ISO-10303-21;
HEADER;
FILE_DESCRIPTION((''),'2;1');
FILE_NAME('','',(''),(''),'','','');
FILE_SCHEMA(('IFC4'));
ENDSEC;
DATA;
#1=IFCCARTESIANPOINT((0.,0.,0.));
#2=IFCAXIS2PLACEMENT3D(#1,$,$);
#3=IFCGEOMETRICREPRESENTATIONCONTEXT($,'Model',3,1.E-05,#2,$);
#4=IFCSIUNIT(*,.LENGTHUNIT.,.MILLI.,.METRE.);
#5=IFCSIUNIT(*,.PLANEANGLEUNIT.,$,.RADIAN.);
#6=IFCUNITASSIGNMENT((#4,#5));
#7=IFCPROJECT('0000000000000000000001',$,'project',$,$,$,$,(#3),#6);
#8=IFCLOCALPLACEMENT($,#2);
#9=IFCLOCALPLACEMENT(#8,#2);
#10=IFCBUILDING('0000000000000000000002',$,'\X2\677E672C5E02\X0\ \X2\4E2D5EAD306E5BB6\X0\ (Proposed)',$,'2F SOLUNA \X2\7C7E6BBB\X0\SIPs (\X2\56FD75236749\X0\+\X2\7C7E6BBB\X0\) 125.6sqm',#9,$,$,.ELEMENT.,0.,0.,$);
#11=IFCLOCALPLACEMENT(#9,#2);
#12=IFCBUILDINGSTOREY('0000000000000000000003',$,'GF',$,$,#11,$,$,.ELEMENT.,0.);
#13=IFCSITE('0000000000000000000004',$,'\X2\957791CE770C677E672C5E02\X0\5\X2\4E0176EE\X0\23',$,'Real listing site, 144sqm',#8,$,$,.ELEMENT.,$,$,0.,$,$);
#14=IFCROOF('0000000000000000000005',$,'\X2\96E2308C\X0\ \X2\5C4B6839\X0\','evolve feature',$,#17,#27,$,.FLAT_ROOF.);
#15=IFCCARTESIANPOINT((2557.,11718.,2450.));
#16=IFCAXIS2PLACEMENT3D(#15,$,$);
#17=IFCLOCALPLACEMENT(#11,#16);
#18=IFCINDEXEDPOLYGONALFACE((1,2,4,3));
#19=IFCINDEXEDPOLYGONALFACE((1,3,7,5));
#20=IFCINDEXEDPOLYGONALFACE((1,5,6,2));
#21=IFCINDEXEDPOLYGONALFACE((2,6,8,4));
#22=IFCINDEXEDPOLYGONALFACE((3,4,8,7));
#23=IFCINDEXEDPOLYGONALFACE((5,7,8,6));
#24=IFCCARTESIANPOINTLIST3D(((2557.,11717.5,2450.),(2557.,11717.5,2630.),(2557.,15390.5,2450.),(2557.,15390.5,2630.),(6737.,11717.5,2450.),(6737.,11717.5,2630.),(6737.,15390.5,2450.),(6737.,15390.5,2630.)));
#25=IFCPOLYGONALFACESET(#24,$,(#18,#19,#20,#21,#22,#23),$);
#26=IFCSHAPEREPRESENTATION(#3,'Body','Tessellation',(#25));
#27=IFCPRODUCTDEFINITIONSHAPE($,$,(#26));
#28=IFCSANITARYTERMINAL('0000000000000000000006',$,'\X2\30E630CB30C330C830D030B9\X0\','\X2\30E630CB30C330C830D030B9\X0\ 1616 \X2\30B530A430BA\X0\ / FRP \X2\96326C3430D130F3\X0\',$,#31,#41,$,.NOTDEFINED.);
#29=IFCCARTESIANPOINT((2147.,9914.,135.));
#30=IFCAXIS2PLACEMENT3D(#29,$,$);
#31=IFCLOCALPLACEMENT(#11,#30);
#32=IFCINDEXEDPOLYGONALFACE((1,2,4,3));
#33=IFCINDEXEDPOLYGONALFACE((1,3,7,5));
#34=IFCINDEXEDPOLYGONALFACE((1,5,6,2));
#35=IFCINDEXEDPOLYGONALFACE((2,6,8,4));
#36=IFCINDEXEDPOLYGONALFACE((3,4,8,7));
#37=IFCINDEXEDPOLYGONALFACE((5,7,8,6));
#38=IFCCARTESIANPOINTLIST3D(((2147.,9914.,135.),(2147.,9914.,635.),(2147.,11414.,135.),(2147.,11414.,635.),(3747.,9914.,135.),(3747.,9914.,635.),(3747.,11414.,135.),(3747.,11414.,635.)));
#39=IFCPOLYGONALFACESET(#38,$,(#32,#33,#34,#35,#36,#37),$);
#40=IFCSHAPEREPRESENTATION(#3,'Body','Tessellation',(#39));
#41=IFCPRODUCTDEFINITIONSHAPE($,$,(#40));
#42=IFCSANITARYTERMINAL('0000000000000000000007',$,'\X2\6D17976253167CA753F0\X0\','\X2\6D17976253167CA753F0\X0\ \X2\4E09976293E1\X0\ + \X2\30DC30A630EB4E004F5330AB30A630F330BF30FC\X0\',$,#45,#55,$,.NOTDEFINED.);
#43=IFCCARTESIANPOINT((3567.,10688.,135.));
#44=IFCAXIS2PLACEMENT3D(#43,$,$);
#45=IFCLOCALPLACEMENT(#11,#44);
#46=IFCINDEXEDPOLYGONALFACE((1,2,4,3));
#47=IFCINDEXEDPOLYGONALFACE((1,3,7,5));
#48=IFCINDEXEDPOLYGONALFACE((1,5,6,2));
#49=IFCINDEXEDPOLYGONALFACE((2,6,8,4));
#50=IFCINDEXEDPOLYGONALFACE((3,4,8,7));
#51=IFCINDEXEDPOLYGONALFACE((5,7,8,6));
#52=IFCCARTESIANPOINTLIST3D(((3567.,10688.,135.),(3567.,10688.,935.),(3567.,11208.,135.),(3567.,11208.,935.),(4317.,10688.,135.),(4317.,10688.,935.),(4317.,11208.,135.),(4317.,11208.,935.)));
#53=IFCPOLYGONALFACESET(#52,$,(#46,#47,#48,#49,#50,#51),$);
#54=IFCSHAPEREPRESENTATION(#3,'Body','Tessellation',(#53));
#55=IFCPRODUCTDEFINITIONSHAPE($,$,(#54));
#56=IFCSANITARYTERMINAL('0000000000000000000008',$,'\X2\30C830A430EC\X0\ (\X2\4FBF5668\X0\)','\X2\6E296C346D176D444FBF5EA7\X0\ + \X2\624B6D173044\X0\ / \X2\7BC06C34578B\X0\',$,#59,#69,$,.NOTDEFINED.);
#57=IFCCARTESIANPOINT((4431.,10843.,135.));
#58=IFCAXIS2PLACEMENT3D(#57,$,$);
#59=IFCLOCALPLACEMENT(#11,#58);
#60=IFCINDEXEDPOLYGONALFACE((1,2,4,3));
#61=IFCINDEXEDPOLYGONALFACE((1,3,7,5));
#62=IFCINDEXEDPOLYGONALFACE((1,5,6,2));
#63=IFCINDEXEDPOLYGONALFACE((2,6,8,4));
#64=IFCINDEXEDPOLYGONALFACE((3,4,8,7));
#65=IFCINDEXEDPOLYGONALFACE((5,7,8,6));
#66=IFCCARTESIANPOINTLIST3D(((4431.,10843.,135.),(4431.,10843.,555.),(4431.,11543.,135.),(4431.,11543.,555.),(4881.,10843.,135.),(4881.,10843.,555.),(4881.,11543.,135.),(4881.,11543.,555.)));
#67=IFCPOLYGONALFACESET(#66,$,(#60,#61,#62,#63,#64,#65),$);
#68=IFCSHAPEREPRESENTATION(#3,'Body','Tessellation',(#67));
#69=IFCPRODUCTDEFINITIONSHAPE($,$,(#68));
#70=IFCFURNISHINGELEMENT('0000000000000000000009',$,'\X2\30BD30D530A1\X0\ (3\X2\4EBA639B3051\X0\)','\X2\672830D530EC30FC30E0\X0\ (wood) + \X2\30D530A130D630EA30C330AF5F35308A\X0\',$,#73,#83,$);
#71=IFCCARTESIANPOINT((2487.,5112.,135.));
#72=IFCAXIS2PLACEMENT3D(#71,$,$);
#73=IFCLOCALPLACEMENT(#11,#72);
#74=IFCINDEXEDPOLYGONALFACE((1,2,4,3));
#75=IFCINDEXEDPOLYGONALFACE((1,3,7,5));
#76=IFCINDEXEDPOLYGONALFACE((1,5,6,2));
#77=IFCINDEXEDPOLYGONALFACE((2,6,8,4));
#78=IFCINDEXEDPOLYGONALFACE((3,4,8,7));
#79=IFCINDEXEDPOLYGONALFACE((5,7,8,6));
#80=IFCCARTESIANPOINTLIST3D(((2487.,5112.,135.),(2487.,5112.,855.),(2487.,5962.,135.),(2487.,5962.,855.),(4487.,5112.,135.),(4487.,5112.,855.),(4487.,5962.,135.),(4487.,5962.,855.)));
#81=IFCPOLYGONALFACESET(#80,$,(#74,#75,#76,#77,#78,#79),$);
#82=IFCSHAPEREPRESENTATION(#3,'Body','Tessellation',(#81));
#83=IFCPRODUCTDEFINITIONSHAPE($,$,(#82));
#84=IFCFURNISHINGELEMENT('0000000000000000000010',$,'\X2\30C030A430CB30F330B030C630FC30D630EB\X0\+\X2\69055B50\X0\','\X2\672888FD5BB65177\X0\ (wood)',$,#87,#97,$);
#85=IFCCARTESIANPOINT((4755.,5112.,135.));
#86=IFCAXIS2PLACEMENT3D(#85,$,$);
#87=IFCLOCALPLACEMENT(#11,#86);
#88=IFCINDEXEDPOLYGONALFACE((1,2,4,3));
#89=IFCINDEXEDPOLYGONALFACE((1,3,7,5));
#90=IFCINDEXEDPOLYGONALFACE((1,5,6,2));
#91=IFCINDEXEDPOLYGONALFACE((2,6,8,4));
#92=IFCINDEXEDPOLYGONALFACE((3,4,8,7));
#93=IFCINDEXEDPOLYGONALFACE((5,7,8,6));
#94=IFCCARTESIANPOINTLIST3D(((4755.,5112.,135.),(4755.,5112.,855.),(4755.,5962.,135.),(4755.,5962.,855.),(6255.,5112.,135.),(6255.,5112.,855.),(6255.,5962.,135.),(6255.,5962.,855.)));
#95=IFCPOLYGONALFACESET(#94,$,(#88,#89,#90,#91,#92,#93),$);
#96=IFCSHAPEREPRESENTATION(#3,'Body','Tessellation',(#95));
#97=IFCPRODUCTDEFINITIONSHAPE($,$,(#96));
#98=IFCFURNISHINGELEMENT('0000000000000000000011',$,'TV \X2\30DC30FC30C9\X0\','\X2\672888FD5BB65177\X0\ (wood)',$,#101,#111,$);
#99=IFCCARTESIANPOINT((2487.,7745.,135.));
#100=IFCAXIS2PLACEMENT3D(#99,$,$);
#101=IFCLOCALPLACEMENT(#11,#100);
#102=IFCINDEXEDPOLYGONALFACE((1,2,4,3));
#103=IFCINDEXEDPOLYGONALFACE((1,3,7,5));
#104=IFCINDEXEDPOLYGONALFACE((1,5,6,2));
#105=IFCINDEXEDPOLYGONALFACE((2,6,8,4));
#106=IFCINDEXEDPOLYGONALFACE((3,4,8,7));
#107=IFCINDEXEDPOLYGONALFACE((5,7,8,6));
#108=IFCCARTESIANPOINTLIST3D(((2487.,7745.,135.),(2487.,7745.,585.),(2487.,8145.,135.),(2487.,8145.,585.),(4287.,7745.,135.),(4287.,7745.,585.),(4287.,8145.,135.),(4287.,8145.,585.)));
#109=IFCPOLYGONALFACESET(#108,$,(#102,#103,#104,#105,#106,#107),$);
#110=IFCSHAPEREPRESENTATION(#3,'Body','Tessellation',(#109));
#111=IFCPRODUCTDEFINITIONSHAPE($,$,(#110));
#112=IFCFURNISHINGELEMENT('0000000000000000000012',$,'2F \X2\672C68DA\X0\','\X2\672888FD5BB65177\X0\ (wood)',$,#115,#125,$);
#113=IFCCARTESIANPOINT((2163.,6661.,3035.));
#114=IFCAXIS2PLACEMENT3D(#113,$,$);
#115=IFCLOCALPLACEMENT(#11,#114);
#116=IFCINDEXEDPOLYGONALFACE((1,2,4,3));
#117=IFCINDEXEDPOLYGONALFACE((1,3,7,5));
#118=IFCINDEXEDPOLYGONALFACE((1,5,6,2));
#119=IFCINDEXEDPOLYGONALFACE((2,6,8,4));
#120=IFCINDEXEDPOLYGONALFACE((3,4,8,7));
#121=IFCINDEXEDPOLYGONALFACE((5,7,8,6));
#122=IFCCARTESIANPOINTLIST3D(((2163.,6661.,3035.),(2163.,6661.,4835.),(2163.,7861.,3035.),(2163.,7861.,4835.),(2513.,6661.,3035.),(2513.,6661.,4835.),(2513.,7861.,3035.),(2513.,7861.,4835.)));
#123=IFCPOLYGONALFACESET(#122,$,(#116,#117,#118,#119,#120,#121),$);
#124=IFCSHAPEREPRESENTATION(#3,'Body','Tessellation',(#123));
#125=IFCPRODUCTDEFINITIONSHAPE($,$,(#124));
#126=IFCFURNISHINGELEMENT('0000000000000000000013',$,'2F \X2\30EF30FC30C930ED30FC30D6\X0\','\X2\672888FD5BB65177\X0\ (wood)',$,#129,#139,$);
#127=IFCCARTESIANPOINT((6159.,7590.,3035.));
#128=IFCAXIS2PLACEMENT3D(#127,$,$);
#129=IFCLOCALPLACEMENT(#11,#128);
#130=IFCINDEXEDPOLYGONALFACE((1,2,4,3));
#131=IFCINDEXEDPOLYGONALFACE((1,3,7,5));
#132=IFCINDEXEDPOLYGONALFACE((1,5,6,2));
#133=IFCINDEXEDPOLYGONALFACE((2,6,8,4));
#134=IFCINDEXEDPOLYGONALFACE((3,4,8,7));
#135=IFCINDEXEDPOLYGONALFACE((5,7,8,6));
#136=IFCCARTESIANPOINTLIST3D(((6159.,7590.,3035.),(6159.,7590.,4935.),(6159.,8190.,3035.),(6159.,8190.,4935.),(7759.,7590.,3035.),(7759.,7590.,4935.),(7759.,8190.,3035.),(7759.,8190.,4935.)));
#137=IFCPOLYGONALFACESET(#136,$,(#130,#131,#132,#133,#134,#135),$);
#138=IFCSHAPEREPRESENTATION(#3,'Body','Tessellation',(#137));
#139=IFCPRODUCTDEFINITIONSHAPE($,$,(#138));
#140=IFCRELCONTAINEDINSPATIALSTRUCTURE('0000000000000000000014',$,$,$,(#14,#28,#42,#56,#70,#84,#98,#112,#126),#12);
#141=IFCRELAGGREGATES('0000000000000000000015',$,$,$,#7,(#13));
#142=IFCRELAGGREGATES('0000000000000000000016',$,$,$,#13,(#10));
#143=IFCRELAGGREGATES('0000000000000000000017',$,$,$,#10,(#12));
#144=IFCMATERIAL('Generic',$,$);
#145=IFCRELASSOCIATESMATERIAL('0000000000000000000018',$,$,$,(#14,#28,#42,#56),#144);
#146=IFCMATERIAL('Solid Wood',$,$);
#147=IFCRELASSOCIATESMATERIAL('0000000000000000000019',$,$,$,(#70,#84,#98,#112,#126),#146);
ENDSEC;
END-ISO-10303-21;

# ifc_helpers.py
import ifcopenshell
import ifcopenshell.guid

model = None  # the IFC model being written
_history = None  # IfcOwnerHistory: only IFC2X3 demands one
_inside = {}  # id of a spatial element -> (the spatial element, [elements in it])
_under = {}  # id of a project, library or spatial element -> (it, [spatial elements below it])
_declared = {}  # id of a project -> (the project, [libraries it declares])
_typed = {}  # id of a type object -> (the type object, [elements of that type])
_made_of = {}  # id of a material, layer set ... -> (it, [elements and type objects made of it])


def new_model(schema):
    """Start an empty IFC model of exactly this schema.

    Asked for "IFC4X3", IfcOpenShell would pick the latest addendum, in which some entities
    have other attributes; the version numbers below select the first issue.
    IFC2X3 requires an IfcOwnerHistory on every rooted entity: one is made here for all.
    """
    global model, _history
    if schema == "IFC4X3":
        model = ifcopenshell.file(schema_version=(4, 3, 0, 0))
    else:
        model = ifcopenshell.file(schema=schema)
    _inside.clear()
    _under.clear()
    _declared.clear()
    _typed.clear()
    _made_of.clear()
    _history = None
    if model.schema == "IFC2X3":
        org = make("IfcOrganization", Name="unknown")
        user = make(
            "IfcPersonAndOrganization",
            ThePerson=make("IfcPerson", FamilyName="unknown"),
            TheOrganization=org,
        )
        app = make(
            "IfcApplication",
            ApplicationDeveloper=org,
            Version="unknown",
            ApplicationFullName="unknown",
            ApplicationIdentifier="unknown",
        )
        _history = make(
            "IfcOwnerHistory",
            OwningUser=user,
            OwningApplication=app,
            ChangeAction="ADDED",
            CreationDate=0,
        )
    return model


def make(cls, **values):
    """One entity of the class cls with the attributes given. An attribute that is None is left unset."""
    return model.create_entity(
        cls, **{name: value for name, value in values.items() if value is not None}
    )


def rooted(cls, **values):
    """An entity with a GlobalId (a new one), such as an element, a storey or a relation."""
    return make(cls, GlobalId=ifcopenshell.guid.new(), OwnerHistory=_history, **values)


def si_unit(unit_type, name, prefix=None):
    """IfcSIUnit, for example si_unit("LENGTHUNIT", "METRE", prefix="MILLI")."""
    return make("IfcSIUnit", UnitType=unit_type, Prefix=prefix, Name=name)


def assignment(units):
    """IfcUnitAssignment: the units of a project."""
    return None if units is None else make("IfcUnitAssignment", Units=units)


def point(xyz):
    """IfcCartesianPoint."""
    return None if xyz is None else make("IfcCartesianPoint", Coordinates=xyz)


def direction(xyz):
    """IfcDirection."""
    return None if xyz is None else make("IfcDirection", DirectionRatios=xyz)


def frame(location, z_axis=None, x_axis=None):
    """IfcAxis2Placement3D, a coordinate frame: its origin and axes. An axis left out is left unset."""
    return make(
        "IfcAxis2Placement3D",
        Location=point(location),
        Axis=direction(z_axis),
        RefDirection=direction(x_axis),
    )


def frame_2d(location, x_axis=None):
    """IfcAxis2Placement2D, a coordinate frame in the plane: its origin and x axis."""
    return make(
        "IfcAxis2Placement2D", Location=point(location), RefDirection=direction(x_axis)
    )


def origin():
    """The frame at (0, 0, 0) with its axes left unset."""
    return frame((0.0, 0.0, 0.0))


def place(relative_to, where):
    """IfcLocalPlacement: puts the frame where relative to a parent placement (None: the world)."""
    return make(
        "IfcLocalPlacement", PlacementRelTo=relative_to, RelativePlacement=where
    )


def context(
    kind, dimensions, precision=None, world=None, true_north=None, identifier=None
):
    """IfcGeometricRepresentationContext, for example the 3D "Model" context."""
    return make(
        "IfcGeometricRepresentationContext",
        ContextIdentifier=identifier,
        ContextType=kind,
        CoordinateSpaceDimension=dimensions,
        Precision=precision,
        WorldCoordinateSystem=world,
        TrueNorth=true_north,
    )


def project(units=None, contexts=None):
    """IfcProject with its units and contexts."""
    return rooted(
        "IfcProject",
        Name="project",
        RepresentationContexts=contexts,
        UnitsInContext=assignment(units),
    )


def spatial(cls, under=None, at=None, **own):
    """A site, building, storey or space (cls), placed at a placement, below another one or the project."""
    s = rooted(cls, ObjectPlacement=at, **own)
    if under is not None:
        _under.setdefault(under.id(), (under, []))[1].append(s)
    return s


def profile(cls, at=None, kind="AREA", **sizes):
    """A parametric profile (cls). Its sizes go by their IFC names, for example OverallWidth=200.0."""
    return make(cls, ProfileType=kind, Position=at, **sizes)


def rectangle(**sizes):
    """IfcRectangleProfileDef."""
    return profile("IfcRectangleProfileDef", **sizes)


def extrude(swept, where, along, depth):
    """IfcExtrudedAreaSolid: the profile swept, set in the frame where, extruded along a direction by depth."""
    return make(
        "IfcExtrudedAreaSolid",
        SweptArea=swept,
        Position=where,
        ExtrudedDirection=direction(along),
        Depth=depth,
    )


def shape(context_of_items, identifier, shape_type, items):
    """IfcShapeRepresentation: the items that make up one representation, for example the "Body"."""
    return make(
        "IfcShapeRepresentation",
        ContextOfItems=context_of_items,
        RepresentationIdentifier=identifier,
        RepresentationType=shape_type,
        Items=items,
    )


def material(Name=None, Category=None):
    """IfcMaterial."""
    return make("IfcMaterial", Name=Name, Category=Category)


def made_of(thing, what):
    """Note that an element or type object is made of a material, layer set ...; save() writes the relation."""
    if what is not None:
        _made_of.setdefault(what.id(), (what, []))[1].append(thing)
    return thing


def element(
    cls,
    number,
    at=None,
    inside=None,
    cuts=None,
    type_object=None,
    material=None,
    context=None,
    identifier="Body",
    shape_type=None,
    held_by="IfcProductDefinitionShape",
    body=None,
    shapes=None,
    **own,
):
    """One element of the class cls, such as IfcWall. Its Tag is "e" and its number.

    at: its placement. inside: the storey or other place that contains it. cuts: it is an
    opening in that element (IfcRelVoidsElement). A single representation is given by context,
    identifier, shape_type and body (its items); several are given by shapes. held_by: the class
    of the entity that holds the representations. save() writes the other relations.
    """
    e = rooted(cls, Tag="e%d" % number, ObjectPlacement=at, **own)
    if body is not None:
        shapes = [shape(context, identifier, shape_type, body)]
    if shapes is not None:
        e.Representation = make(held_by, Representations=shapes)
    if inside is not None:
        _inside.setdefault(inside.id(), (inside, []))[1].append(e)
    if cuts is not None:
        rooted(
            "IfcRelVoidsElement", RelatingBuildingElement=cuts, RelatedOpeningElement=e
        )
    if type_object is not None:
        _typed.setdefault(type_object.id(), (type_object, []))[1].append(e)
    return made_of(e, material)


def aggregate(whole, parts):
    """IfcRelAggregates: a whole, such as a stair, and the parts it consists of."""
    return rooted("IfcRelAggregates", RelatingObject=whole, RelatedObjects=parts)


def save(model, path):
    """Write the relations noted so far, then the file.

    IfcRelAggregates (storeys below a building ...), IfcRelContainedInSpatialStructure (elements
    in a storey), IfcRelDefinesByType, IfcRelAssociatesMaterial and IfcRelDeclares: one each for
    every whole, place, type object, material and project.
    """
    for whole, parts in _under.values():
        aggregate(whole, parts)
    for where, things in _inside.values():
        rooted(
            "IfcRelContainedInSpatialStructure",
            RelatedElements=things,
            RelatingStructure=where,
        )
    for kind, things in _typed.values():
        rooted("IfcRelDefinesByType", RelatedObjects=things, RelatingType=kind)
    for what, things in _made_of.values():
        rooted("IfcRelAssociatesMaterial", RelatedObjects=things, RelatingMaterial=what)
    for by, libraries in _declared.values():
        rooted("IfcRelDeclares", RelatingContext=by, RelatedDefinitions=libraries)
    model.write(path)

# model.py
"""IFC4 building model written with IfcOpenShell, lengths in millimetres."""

from ifc_helpers import new_model, si_unit, frame, frame_2d, origin, place, context, project, spatial, rectangle, extrude, material, element, save


model = new_model("IFC4")

# Units and contexts
model_context = context("Model", 3, precision=1e-05, world=origin())
ifc_project = project(units=[si_unit("LENGTHUNIT", "METRE", prefix="MILLI"), si_unit("PLANEANGLEUNIT", "RADIAN")], contexts=[model_context])

# Site, building, storey
site_placement = place(None, origin())
site = spatial("IfcSite", under=ifc_project, at=site_placement, Name="長野県松本市5丁目23", ObjectType="Real listing site, 144sqm", CompositionType="ELEMENT", RefElevation=0.0)
building_placement = place(site_placement, origin())
building = spatial("IfcBuilding", under=site, at=building_placement, Name="松本市 中庭の家 (Proposed)", ObjectType="2F SOLUNA 籾殻SIPs (国産杉+籾殻) 125.6sqm", CompositionType="ELEMENT", ElevationOfRefHeight=0.0, ElevationOfTerrain=0.0)
storey_placement = place(building_placement, origin())
storey = spatial("IfcBuildingStorey", under=building, at=storey_placement, Name="GF", CompositionType="ELEMENT", Elevation=0.0)

# Shared definitions
ifc_material_1 = material(Name="Generic")

# Shared definitions
ifc_material_2 = material(Name="Solid Wood")

# Roof
roof_1_placement = place(storey_placement, frame((2557.0, 11718.0, 2450.0)))
element("IfcRoof", 1, at=roof_1_placement, inside=storey, material=ifc_material_1, Name="離れ 屋根", Description="evolve feature", PredefinedType="FLAT_ROOF", context=model_context, shape_type="SweptSolid", body=[
    extrude(rectangle(XDim=4180.0, YDim=3673.0, at=frame_2d((2090.0, 1836.0))), frame((2557.0, 11718.0, 2450.0)), (0.0, 0.0, 1.0), 180.0),
])

# Sanitary terminals
sanitary_terminal_1_placement = place(storey_placement, frame((2147.0, 9914.0, 135.0)))
element("IfcSanitaryTerminal", 2, at=sanitary_terminal_1_placement, inside=storey, material=ifc_material_1, Name="ユニットバス", Description="ユニットバス 1616 サイズ / FRP 防水パン", PredefinedType="NOTDEFINED", context=model_context, shape_type="SweptSolid", body=[
    extrude(rectangle(XDim=1600.0, YDim=1500.0, at=frame_2d((800.0, 750.0))), frame((2147.0, 9914.0, 135.0)), (0.0, 0.0, 1.0), 500.0),
])
sanitary_terminal_2_placement = place(storey_placement, frame((3567.0, 10688.0, 135.0)))
element("IfcSanitaryTerminal", 3, at=sanitary_terminal_2_placement, inside=storey, material=ifc_material_1, Name="洗面化粧台", Description="洗面化粧台 三面鏡 + ボウル一体カウンター", PredefinedType="NOTDEFINED", context=model_context, shape_type="SweptSolid", body=[
    extrude(rectangle(XDim=750.0, YDim=520.0, at=frame_2d((375.0, 260.0))), frame((3567.0, 10688.0, 135.0)), (0.0, 0.0, 1.0), 800.0),
])
sanitary_terminal_3_placement = place(storey_placement, frame((4431.0, 10843.0, 135.0)))
element("IfcSanitaryTerminal", 4, at=sanitary_terminal_3_placement, inside=storey, material=ifc_material_1, Name="トイレ (便器)", Description="温水洗浄便座 + 手洗い / 節水型", PredefinedType="NOTDEFINED", context=model_context, shape_type="SweptSolid", body=[
    extrude(rectangle(XDim=450.0, YDim=700.0, at=frame_2d((225.0, 350.0))), frame((4431.0, 10843.0, 135.0)), (0.0, 0.0, 1.0), 420.0),
])

# Furnishing elements
furnishing_1_placement = place(storey_placement, frame((2487.0, 5112.0, 135.0)))
element("IfcFurnishingElement", 5, at=furnishing_1_placement, inside=storey, material=ifc_material_2, Name="ソファ (3人掛け)", Description="木フレーム (wood) + ファブリック張り", context=model_context, shape_type="SweptSolid", body=[
    extrude(rectangle(XDim=2000.0, YDim=850.0, at=frame_2d((1000.0, 425.0))), frame((2487.0, 5112.0, 135.0)), (0.0, 0.0, 1.0), 720.0),
])
furnishing_2_placement = place(storey_placement, frame((4755.0, 5112.0, 135.0)))
element("IfcFurnishingElement", 6, at=furnishing_2_placement, inside=storey, material=ifc_material_2, Name="ダイニングテーブル+椅子", Description="木製家具 (wood)", context=model_context, shape_type="SweptSolid", body=[
    extrude(rectangle(XDim=1500.0, YDim=850.0, at=frame_2d((750.0, 425.0))), frame((4755.0, 5112.0, 135.0)), (0.0, 0.0, 1.0), 720.0),
])
furnishing_3_placement = place(storey_placement, frame((2487.0, 7745.0, 135.0)))
element("IfcFurnishingElement", 7, at=furnishing_3_placement, inside=storey, material=ifc_material_2, Name="TV ボード", Description="木製家具 (wood)", context=model_context, shape_type="SweptSolid", body=[
    extrude(rectangle(XDim=1800.0, YDim=400.0, at=frame_2d((900.0, 200.0))), frame((2487.0, 7745.0, 135.0)), (0.0, 0.0, 1.0), 450.0),
])
furnishing_4_placement = place(storey_placement, frame((2163.0, 6661.0, 3035.0)))
element("IfcFurnishingElement", 8, at=furnishing_4_placement, inside=storey, material=ifc_material_2, Name="2F 本棚", Description="木製家具 (wood)", context=model_context, shape_type="SweptSolid", body=[
    extrude(rectangle(XDim=350.0, YDim=1200.0, at=frame_2d((175.0, 600.0))), frame((2163.0, 6661.0, 3035.0)), (0.0, 0.0, 1.0), 1800.0),
])
furnishing_5_placement = place(storey_placement, frame((6159.0, 7590.0, 3035.0)))
element("IfcFurnishingElement", 9, at=furnishing_5_placement, inside=storey, material=ifc_material_2, Name="2F ワードローブ", Description="木製家具 (wood)", context=model_context, shape_type="SweptSolid", body=[
    extrude(rectangle(XDim=1600.0, YDim=600.0, at=frame_2d((800.0, 300.0))), frame((6159.0, 7590.0, 3035.0)), (0.0, 0.0, 1.0), 1900.0),
])

save(model, "model.ifc")
